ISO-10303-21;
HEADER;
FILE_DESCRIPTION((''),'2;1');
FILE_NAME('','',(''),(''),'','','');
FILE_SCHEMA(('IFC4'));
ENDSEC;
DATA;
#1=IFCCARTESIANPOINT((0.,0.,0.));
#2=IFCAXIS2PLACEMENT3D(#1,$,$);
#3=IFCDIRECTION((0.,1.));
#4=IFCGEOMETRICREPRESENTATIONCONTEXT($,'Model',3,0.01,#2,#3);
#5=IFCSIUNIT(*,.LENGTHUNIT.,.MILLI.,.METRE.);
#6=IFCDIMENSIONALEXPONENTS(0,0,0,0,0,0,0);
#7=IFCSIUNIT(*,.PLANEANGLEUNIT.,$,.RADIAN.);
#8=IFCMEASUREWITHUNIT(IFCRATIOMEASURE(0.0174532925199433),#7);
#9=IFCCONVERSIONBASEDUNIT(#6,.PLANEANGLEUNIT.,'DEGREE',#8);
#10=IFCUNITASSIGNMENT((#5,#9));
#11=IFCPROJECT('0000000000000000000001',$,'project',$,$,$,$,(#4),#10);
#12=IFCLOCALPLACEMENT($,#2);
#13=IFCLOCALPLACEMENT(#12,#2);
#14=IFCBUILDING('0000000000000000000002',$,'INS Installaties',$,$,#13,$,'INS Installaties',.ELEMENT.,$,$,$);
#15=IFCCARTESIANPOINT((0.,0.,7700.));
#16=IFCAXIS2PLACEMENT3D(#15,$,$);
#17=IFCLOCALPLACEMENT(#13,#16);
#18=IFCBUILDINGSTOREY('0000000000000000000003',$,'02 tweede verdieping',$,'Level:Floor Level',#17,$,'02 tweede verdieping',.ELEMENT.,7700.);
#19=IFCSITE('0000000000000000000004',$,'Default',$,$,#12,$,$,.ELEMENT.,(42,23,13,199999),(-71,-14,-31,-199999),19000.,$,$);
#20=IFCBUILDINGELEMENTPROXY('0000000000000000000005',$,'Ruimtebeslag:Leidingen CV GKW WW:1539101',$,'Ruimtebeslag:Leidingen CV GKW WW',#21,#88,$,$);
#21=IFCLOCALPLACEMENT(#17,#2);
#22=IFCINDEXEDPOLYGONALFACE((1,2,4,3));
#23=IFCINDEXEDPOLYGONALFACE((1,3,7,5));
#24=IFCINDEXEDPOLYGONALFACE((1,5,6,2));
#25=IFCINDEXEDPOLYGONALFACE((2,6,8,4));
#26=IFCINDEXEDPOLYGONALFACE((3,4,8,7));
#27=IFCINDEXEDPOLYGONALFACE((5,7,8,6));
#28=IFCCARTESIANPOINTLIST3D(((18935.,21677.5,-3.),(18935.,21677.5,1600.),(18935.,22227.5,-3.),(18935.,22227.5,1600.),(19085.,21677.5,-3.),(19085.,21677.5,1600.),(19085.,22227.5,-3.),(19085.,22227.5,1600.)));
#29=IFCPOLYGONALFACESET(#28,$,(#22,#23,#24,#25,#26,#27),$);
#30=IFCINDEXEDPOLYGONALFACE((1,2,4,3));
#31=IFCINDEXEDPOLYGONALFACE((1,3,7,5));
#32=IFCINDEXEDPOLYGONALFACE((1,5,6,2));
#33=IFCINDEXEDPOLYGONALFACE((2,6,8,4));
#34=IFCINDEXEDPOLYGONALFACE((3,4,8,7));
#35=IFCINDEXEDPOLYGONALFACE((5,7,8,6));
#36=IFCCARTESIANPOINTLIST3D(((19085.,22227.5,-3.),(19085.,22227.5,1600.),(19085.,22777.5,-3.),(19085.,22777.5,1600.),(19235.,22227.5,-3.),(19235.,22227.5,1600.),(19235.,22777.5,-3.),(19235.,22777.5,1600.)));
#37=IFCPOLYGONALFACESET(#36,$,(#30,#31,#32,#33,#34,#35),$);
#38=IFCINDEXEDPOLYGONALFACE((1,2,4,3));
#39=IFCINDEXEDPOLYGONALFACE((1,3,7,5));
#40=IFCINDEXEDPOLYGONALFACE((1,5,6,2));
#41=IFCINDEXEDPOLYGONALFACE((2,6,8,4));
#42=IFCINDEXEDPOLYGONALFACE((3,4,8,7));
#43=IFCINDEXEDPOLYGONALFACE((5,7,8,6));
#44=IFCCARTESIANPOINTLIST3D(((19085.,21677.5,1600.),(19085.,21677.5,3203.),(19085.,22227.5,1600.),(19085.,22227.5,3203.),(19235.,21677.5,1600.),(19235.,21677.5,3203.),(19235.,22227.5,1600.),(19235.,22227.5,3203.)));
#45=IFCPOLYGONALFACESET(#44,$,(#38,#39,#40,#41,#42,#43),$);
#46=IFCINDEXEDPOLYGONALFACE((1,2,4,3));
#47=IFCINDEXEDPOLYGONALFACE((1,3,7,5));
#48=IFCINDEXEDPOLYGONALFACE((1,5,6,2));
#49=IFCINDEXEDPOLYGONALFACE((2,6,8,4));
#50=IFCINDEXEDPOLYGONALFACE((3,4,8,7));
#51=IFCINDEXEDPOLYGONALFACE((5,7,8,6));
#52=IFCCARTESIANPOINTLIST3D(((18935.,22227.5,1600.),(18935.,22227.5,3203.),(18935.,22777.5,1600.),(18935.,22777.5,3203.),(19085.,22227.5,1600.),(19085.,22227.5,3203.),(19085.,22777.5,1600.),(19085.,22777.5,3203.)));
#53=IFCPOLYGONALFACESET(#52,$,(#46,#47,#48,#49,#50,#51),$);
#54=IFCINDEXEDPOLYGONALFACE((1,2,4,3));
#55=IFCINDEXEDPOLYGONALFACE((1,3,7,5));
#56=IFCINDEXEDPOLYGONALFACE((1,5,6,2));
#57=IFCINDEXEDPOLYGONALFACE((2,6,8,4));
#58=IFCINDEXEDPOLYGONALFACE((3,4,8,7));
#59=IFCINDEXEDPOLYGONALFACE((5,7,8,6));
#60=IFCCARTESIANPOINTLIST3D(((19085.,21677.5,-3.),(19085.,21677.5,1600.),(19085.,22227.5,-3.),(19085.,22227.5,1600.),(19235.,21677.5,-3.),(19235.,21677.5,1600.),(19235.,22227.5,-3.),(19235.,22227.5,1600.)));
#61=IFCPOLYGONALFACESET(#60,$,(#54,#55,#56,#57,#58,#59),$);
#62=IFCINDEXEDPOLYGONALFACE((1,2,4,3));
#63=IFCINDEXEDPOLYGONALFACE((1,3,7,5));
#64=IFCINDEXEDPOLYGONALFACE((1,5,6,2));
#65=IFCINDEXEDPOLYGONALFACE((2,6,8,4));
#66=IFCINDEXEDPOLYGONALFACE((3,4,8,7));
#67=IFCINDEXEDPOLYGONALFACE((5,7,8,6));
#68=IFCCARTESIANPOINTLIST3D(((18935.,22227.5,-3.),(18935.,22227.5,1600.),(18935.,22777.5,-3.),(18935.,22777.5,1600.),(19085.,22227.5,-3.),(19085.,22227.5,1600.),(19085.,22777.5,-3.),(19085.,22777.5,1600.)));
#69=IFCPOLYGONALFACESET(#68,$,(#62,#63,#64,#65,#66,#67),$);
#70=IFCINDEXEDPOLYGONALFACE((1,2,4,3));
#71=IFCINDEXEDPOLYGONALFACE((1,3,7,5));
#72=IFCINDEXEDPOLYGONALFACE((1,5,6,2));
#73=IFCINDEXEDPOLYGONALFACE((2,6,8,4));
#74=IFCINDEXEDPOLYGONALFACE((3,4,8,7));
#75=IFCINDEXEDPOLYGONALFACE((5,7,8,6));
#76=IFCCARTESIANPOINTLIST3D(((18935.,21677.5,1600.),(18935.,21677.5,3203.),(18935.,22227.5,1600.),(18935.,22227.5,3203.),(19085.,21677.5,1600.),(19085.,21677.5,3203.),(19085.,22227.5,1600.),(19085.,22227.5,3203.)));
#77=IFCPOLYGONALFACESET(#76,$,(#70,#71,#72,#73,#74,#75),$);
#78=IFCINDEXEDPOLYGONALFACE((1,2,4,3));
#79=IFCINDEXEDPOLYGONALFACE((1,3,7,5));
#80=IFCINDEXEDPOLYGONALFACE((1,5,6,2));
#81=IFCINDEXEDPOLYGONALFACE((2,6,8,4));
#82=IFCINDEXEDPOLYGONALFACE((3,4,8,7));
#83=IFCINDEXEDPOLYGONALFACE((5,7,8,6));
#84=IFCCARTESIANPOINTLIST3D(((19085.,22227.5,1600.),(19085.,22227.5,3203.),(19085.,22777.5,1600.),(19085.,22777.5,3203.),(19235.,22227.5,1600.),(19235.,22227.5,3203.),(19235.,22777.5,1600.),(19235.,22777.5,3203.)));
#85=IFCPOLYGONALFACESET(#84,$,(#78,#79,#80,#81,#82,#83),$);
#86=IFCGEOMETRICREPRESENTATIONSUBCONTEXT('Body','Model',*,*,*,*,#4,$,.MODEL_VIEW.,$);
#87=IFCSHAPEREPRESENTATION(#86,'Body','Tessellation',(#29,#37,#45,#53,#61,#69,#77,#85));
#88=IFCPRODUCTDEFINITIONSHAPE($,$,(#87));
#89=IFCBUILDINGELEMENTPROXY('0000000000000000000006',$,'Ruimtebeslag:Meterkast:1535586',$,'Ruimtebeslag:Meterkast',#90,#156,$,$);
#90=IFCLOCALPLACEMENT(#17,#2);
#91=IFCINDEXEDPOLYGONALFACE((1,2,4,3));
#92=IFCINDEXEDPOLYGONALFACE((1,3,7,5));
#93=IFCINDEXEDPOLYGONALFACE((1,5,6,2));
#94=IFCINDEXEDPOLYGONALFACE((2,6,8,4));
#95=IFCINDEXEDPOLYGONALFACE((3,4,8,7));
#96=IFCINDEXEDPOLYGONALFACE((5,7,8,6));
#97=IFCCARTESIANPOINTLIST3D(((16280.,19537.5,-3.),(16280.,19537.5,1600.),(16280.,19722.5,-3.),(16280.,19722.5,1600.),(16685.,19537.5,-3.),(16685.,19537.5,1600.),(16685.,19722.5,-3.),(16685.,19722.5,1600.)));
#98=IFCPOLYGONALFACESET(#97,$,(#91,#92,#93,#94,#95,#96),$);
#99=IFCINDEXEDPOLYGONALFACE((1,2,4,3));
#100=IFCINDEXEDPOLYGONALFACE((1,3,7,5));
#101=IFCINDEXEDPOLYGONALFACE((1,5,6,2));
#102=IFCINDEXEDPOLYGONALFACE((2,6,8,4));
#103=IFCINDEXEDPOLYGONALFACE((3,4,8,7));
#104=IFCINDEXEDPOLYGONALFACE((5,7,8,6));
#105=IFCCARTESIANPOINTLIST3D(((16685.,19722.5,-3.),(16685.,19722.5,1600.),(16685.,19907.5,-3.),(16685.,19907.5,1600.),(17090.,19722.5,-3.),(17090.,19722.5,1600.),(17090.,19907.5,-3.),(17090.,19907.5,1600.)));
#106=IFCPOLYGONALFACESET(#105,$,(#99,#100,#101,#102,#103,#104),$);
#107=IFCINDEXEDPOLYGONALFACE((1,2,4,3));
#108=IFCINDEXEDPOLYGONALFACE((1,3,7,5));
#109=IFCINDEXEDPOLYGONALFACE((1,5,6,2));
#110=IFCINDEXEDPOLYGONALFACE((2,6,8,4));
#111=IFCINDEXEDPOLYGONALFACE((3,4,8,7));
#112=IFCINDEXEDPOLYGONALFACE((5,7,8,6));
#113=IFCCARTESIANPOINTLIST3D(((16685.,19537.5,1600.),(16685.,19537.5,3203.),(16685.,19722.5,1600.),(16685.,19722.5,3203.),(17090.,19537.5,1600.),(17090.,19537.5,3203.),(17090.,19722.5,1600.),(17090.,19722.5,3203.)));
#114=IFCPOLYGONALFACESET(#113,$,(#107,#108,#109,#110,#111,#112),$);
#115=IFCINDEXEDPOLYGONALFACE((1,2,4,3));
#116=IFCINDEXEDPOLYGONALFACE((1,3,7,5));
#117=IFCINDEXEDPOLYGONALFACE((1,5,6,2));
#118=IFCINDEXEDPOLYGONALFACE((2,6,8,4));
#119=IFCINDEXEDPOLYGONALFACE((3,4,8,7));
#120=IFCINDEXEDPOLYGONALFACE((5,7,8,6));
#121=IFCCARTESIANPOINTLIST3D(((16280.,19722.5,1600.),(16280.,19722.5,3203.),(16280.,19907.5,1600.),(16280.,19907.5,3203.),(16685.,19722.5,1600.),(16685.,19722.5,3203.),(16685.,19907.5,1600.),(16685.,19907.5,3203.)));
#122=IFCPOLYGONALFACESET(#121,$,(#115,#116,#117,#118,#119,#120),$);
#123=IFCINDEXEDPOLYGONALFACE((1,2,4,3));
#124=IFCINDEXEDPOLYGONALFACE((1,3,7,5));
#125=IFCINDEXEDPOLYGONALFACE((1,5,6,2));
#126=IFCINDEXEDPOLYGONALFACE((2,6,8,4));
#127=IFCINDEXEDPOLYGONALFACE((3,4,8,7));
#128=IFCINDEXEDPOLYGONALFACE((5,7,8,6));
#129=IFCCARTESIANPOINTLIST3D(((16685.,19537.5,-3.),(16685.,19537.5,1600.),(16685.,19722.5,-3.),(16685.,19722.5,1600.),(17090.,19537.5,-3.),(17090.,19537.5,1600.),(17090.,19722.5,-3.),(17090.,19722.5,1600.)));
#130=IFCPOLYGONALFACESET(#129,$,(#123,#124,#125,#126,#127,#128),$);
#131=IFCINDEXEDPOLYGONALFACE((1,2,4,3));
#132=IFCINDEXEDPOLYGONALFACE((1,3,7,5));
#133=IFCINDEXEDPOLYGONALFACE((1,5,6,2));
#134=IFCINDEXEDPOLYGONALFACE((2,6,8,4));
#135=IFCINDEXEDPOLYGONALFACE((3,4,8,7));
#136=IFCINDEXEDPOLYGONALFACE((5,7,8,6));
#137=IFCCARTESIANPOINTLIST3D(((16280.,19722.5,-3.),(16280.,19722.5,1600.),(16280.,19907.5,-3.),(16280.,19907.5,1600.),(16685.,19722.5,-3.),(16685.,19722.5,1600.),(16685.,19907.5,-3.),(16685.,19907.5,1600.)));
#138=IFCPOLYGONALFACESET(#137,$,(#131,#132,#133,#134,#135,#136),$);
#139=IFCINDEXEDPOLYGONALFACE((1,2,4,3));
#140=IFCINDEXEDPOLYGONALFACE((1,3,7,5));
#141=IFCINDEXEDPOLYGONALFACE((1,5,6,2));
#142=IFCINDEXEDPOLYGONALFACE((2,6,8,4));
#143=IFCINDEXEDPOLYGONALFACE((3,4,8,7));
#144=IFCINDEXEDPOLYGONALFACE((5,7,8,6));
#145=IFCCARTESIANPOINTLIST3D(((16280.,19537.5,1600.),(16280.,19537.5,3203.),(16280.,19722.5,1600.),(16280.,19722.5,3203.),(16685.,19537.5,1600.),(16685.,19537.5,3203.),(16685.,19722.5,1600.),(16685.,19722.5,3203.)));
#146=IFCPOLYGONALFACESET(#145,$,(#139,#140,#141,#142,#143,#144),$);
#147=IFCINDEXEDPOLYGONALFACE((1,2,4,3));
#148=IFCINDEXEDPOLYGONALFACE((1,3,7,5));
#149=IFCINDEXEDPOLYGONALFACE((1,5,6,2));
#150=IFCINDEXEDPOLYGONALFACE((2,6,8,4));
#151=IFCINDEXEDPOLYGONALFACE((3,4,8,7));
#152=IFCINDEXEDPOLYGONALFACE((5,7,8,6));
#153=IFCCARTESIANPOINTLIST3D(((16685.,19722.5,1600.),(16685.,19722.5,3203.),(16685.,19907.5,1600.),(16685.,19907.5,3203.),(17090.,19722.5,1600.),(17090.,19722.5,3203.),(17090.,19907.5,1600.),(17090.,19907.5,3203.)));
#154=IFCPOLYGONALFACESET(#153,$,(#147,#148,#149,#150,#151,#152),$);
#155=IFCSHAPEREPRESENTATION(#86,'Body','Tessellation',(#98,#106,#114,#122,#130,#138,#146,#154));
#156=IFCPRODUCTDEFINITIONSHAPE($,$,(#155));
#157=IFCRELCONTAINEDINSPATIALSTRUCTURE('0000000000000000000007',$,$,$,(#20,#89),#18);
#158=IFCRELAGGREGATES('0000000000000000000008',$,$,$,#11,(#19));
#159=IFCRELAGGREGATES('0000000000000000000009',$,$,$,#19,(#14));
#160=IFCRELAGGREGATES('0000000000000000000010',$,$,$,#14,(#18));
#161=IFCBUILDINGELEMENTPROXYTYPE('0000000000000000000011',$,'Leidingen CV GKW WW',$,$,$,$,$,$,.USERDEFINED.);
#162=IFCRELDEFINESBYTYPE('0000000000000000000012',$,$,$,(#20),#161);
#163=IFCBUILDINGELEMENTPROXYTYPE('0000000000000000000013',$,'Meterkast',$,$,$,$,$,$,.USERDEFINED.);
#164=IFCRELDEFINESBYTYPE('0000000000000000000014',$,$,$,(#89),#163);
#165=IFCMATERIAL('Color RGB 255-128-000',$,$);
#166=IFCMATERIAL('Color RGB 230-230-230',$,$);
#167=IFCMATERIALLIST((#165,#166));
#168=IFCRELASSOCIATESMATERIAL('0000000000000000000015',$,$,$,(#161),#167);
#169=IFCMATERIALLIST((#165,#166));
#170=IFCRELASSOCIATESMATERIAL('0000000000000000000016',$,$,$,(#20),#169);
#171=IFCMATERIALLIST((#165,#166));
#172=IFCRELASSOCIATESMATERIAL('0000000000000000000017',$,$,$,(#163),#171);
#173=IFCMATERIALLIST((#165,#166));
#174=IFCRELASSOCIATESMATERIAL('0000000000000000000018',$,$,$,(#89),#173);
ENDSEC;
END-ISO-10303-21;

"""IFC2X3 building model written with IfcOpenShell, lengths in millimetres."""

from ifc_helpers import new_model, entity, si_unit, converted_unit, direction, frame, frame_2d, origin, origin_2d_with_axis, place, context, subcontext, project, spatial, rectangle, extrude, source, transform, mapped, material, material_list, type_object, type_shapes, element, save


model = new_model("IFC2X3")

# Units and contexts
model_context = context("Model", 3, precision=0.01, world=origin(), true_north=direction((0.0, 1.0)))
body_context = subcontext(model_context, "Body", "Model", "MODEL_VIEW")
ifc_project = project(units=[si_unit("LENGTHUNIT", "METRE", prefix="MILLI"), converted_unit("PLANEANGLEUNIT", "DEGREE", entity("IfcRatioMeasure", 0.0174532925199433), si_unit("PLANEANGLEUNIT", "RADIAN"), dimensions=[0, 0, 0, 0, 0, 0, 0])], contexts=[model_context])

# Site, building, storey
site_placement = place(None, origin())
site = spatial("IfcSite", under=ifc_project, at=site_placement, Name="Default", CompositionType="ELEMENT", RefLatitude=(42, 23, 13, 199999), RefLongitude=(-71, -14, -31, -199999), RefElevation=19000.0)
building_placement = place(site_placement, origin())
building = spatial("IfcBuilding", under=site, at=building_placement, Name="INS Installaties", LongName="INS Installaties", CompositionType="ELEMENT")
storey_placement = place(building_placement, frame((0.0, 0.0, 7700.0)))
storey = spatial("IfcBuildingStorey", under=building, at=storey_placement, Name="02 tweede verdieping", ObjectType="Level:Floor Level", LongName="02 tweede verdieping", CompositionType="ELEMENT", Elevation=7700.0)

# Building element proxies
ifc_material_1 = material(Name="Color RGB 255-128-000")
ifc_material_2 = material(Name="Color RGB 230-230-230")
ifc_material_list_1 = material_list([ifc_material_1, ifc_material_2])
ifc_material_list_2 = material_list([ifc_material_1, ifc_material_2])
building_element_proxy_type_1 = type_object("IfcBuildingElementProxyType", Name="Leidingen CV GKW WW", PredefinedType="USERDEFINED", material=ifc_material_list_2)
shared_shape_1 = source(origin(), body_context, "Body", "SweptSolid", [
    extrude(rectangle(XDim=550.0, YDim=150.0, at=frame_2d((0.0, 0.0), x_axis=(1.0, 0.0))), frame((75.0, 275.0, -3203.0), z_axis=(0.0, 0.0, 1.0), x_axis=(0.0, -1.0, 0.0)), (0.0, 0.0, 1.0), 1603.0),
    extrude(rectangle(XDim=550.0, YDim=150.0, at=origin_2d_with_axis()), frame((-75.0, -275.0, -3203.0), z_axis=(0.0, 0.0, 1.0), x_axis=(0.0, 1.0, 0.0)), (0.0, 0.0, 1.0), 1603.0),
    extrude(rectangle(XDim=150.0, YDim=550.0, at=frame_2d((0.0, 0.0), x_axis=(1.0, 0.0))), frame((-75.0, 275.0, -1600.0), z_axis=(0.0, 0.0, 1.0), x_axis=(-1.0, 0.0, 0.0)), (0.0, 0.0, 1.0), 1603.0),
    extrude(rectangle(XDim=150.0, YDim=550.0, at=frame_2d((0.0, 0.0), x_axis=(1.0, 0.0))), frame((75.0, -275.0, -1600.0)), (0.0, 0.0, 1.0), 1603.0),
    extrude(rectangle(XDim=150.0, YDim=550.0, at=origin_2d_with_axis()), frame((-75.0, 275.0, -3203.0), z_axis=(0.0, 0.0, 1.0), x_axis=(-1.0, 0.0, 0.0)), (0.0, 0.0, 1.0), 1603.0),
    extrude(rectangle(XDim=150.0, YDim=550.0, at=origin_2d_with_axis()), frame((75.0, -275.0, -3203.0)), (0.0, 0.0, 1.0), 1603.0),
    extrude(rectangle(XDim=550.0, YDim=150.0, at=origin_2d_with_axis()), frame((75.0, 275.0, -1600.0), z_axis=(0.0, 0.0, 1.0), x_axis=(0.0, -1.0, 0.0)), (0.0, 0.0, 1.0), 1603.0),
    extrude(rectangle(XDim=550.0, YDim=150.0, at=origin_2d_with_axis()), frame((-75.0, -275.0, -1600.0), z_axis=(0.0, 0.0, 1.0), x_axis=(0.0, 1.0, 0.0)), (0.0, 0.0, 1.0), 1603.0),
])
type_shapes(building_element_proxy_type_1, [shared_shape_1])
proxy_1_placement = place(storey_placement, frame((19085.0, 22227.5, 3200.0), z_axis=(0.0, 0.0, 1.0), x_axis=(-1.0, 0.0, 0.0)))
element("IfcBuildingElementProxy", 1, at=proxy_1_placement, inside=storey, type_object=building_element_proxy_type_1, material=ifc_material_list_1, Name="Ruimtebeslag:Leidingen CV GKW WW:1539101", ObjectType="Ruimtebeslag:Leidingen CV GKW WW", context=body_context, shape_type="MappedRepresentation", body=[
    mapped(shared_shape_1, transform((0.0, 0.0, 0.0), scale=1.0)),
])
ifc_material_list_3 = material_list([ifc_material_1, ifc_material_2])
ifc_material_list_4 = material_list([ifc_material_1, ifc_material_2])
building_element_proxy_type_2 = type_object("IfcBuildingElementProxyType", Name="Meterkast", PredefinedType="USERDEFINED", material=ifc_material_list_4)
shared_shape_2 = source(origin(), body_context, "Body", "SweptSolid", [
    extrude(rectangle(XDim=185.0, YDim=405.0, at=origin_2d_with_axis()), frame((202.5, 92.5, -3203.0), z_axis=(0.0, 0.0, 1.0), x_axis=(0.0, -1.0, 0.0)), (0.0, 0.0, 1.0), 1603.0),
    extrude(rectangle(XDim=185.0, YDim=405.0, at=origin_2d_with_axis()), frame((-202.5, -92.5, -3203.0), z_axis=(0.0, 0.0, 1.0), x_axis=(0.0, 1.0, 0.0)), (0.0, 0.0, 1.0), 1603.0),
    extrude(rectangle(XDim=405.0, YDim=185.0, at=frame_2d((0.0, 0.0), x_axis=(1.0, 0.0))), frame((-202.5, 92.5, -1600.0), z_axis=(0.0, 0.0, 1.0), x_axis=(-1.0, 0.0, 0.0)), (0.0, 0.0, 1.0), 1603.0),
    extrude(rectangle(XDim=405.0, YDim=185.0, at=frame_2d((0.0, 0.0), x_axis=(1.0, 0.0))), frame((202.5, -92.5, -1600.0)), (0.0, 0.0, 1.0), 1603.0),
    extrude(rectangle(XDim=405.0, YDim=185.0, at=origin_2d_with_axis()), frame((-202.5, 92.5, -3203.0), z_axis=(0.0, 0.0, 1.0), x_axis=(-1.0, 0.0, 0.0)), (0.0, 0.0, 1.0), 1603.0),
    extrude(rectangle(XDim=405.0, YDim=185.0, at=frame_2d((0.0, 0.0), x_axis=(1.0, 0.0))), frame((202.5, -92.5, -3203.0)), (0.0, 0.0, 1.0), 1603.0),
    extrude(rectangle(XDim=185.0, YDim=405.0, at=origin_2d_with_axis()), frame((202.5, 92.5, -1600.0), z_axis=(0.0, 0.0, 1.0), x_axis=(0.0, -1.0, 0.0)), (0.0, 0.0, 1.0), 1603.0),
    extrude(rectangle(XDim=185.0, YDim=405.0, at=origin_2d_with_axis()), frame((-202.5, -92.5, -1600.0), z_axis=(0.0, 0.0, 1.0), x_axis=(0.0, 1.0, 0.0)), (0.0, 0.0, 1.0), 1603.0),
])
type_shapes(building_element_proxy_type_2, [shared_shape_2])
proxy_2_placement = place(storey_placement, frame((16685.0, 19722.5, 3200.0), z_axis=(0.0, 0.0, 1.0), x_axis=(-1.0, 0.0, 0.0)))
element("IfcBuildingElementProxy", 2, at=proxy_2_placement, inside=storey, type_object=building_element_proxy_type_2, material=ifc_material_list_3, Name="Ruimtebeslag:Meterkast:1535586", ObjectType="Ruimtebeslag:Meterkast", context=body_context, shape_type="MappedRepresentation", body=[
    mapped(shared_shape_2, transform((0.0, 0.0, 0.0), scale=1.0)),
])

save(model, "model.ifc")
